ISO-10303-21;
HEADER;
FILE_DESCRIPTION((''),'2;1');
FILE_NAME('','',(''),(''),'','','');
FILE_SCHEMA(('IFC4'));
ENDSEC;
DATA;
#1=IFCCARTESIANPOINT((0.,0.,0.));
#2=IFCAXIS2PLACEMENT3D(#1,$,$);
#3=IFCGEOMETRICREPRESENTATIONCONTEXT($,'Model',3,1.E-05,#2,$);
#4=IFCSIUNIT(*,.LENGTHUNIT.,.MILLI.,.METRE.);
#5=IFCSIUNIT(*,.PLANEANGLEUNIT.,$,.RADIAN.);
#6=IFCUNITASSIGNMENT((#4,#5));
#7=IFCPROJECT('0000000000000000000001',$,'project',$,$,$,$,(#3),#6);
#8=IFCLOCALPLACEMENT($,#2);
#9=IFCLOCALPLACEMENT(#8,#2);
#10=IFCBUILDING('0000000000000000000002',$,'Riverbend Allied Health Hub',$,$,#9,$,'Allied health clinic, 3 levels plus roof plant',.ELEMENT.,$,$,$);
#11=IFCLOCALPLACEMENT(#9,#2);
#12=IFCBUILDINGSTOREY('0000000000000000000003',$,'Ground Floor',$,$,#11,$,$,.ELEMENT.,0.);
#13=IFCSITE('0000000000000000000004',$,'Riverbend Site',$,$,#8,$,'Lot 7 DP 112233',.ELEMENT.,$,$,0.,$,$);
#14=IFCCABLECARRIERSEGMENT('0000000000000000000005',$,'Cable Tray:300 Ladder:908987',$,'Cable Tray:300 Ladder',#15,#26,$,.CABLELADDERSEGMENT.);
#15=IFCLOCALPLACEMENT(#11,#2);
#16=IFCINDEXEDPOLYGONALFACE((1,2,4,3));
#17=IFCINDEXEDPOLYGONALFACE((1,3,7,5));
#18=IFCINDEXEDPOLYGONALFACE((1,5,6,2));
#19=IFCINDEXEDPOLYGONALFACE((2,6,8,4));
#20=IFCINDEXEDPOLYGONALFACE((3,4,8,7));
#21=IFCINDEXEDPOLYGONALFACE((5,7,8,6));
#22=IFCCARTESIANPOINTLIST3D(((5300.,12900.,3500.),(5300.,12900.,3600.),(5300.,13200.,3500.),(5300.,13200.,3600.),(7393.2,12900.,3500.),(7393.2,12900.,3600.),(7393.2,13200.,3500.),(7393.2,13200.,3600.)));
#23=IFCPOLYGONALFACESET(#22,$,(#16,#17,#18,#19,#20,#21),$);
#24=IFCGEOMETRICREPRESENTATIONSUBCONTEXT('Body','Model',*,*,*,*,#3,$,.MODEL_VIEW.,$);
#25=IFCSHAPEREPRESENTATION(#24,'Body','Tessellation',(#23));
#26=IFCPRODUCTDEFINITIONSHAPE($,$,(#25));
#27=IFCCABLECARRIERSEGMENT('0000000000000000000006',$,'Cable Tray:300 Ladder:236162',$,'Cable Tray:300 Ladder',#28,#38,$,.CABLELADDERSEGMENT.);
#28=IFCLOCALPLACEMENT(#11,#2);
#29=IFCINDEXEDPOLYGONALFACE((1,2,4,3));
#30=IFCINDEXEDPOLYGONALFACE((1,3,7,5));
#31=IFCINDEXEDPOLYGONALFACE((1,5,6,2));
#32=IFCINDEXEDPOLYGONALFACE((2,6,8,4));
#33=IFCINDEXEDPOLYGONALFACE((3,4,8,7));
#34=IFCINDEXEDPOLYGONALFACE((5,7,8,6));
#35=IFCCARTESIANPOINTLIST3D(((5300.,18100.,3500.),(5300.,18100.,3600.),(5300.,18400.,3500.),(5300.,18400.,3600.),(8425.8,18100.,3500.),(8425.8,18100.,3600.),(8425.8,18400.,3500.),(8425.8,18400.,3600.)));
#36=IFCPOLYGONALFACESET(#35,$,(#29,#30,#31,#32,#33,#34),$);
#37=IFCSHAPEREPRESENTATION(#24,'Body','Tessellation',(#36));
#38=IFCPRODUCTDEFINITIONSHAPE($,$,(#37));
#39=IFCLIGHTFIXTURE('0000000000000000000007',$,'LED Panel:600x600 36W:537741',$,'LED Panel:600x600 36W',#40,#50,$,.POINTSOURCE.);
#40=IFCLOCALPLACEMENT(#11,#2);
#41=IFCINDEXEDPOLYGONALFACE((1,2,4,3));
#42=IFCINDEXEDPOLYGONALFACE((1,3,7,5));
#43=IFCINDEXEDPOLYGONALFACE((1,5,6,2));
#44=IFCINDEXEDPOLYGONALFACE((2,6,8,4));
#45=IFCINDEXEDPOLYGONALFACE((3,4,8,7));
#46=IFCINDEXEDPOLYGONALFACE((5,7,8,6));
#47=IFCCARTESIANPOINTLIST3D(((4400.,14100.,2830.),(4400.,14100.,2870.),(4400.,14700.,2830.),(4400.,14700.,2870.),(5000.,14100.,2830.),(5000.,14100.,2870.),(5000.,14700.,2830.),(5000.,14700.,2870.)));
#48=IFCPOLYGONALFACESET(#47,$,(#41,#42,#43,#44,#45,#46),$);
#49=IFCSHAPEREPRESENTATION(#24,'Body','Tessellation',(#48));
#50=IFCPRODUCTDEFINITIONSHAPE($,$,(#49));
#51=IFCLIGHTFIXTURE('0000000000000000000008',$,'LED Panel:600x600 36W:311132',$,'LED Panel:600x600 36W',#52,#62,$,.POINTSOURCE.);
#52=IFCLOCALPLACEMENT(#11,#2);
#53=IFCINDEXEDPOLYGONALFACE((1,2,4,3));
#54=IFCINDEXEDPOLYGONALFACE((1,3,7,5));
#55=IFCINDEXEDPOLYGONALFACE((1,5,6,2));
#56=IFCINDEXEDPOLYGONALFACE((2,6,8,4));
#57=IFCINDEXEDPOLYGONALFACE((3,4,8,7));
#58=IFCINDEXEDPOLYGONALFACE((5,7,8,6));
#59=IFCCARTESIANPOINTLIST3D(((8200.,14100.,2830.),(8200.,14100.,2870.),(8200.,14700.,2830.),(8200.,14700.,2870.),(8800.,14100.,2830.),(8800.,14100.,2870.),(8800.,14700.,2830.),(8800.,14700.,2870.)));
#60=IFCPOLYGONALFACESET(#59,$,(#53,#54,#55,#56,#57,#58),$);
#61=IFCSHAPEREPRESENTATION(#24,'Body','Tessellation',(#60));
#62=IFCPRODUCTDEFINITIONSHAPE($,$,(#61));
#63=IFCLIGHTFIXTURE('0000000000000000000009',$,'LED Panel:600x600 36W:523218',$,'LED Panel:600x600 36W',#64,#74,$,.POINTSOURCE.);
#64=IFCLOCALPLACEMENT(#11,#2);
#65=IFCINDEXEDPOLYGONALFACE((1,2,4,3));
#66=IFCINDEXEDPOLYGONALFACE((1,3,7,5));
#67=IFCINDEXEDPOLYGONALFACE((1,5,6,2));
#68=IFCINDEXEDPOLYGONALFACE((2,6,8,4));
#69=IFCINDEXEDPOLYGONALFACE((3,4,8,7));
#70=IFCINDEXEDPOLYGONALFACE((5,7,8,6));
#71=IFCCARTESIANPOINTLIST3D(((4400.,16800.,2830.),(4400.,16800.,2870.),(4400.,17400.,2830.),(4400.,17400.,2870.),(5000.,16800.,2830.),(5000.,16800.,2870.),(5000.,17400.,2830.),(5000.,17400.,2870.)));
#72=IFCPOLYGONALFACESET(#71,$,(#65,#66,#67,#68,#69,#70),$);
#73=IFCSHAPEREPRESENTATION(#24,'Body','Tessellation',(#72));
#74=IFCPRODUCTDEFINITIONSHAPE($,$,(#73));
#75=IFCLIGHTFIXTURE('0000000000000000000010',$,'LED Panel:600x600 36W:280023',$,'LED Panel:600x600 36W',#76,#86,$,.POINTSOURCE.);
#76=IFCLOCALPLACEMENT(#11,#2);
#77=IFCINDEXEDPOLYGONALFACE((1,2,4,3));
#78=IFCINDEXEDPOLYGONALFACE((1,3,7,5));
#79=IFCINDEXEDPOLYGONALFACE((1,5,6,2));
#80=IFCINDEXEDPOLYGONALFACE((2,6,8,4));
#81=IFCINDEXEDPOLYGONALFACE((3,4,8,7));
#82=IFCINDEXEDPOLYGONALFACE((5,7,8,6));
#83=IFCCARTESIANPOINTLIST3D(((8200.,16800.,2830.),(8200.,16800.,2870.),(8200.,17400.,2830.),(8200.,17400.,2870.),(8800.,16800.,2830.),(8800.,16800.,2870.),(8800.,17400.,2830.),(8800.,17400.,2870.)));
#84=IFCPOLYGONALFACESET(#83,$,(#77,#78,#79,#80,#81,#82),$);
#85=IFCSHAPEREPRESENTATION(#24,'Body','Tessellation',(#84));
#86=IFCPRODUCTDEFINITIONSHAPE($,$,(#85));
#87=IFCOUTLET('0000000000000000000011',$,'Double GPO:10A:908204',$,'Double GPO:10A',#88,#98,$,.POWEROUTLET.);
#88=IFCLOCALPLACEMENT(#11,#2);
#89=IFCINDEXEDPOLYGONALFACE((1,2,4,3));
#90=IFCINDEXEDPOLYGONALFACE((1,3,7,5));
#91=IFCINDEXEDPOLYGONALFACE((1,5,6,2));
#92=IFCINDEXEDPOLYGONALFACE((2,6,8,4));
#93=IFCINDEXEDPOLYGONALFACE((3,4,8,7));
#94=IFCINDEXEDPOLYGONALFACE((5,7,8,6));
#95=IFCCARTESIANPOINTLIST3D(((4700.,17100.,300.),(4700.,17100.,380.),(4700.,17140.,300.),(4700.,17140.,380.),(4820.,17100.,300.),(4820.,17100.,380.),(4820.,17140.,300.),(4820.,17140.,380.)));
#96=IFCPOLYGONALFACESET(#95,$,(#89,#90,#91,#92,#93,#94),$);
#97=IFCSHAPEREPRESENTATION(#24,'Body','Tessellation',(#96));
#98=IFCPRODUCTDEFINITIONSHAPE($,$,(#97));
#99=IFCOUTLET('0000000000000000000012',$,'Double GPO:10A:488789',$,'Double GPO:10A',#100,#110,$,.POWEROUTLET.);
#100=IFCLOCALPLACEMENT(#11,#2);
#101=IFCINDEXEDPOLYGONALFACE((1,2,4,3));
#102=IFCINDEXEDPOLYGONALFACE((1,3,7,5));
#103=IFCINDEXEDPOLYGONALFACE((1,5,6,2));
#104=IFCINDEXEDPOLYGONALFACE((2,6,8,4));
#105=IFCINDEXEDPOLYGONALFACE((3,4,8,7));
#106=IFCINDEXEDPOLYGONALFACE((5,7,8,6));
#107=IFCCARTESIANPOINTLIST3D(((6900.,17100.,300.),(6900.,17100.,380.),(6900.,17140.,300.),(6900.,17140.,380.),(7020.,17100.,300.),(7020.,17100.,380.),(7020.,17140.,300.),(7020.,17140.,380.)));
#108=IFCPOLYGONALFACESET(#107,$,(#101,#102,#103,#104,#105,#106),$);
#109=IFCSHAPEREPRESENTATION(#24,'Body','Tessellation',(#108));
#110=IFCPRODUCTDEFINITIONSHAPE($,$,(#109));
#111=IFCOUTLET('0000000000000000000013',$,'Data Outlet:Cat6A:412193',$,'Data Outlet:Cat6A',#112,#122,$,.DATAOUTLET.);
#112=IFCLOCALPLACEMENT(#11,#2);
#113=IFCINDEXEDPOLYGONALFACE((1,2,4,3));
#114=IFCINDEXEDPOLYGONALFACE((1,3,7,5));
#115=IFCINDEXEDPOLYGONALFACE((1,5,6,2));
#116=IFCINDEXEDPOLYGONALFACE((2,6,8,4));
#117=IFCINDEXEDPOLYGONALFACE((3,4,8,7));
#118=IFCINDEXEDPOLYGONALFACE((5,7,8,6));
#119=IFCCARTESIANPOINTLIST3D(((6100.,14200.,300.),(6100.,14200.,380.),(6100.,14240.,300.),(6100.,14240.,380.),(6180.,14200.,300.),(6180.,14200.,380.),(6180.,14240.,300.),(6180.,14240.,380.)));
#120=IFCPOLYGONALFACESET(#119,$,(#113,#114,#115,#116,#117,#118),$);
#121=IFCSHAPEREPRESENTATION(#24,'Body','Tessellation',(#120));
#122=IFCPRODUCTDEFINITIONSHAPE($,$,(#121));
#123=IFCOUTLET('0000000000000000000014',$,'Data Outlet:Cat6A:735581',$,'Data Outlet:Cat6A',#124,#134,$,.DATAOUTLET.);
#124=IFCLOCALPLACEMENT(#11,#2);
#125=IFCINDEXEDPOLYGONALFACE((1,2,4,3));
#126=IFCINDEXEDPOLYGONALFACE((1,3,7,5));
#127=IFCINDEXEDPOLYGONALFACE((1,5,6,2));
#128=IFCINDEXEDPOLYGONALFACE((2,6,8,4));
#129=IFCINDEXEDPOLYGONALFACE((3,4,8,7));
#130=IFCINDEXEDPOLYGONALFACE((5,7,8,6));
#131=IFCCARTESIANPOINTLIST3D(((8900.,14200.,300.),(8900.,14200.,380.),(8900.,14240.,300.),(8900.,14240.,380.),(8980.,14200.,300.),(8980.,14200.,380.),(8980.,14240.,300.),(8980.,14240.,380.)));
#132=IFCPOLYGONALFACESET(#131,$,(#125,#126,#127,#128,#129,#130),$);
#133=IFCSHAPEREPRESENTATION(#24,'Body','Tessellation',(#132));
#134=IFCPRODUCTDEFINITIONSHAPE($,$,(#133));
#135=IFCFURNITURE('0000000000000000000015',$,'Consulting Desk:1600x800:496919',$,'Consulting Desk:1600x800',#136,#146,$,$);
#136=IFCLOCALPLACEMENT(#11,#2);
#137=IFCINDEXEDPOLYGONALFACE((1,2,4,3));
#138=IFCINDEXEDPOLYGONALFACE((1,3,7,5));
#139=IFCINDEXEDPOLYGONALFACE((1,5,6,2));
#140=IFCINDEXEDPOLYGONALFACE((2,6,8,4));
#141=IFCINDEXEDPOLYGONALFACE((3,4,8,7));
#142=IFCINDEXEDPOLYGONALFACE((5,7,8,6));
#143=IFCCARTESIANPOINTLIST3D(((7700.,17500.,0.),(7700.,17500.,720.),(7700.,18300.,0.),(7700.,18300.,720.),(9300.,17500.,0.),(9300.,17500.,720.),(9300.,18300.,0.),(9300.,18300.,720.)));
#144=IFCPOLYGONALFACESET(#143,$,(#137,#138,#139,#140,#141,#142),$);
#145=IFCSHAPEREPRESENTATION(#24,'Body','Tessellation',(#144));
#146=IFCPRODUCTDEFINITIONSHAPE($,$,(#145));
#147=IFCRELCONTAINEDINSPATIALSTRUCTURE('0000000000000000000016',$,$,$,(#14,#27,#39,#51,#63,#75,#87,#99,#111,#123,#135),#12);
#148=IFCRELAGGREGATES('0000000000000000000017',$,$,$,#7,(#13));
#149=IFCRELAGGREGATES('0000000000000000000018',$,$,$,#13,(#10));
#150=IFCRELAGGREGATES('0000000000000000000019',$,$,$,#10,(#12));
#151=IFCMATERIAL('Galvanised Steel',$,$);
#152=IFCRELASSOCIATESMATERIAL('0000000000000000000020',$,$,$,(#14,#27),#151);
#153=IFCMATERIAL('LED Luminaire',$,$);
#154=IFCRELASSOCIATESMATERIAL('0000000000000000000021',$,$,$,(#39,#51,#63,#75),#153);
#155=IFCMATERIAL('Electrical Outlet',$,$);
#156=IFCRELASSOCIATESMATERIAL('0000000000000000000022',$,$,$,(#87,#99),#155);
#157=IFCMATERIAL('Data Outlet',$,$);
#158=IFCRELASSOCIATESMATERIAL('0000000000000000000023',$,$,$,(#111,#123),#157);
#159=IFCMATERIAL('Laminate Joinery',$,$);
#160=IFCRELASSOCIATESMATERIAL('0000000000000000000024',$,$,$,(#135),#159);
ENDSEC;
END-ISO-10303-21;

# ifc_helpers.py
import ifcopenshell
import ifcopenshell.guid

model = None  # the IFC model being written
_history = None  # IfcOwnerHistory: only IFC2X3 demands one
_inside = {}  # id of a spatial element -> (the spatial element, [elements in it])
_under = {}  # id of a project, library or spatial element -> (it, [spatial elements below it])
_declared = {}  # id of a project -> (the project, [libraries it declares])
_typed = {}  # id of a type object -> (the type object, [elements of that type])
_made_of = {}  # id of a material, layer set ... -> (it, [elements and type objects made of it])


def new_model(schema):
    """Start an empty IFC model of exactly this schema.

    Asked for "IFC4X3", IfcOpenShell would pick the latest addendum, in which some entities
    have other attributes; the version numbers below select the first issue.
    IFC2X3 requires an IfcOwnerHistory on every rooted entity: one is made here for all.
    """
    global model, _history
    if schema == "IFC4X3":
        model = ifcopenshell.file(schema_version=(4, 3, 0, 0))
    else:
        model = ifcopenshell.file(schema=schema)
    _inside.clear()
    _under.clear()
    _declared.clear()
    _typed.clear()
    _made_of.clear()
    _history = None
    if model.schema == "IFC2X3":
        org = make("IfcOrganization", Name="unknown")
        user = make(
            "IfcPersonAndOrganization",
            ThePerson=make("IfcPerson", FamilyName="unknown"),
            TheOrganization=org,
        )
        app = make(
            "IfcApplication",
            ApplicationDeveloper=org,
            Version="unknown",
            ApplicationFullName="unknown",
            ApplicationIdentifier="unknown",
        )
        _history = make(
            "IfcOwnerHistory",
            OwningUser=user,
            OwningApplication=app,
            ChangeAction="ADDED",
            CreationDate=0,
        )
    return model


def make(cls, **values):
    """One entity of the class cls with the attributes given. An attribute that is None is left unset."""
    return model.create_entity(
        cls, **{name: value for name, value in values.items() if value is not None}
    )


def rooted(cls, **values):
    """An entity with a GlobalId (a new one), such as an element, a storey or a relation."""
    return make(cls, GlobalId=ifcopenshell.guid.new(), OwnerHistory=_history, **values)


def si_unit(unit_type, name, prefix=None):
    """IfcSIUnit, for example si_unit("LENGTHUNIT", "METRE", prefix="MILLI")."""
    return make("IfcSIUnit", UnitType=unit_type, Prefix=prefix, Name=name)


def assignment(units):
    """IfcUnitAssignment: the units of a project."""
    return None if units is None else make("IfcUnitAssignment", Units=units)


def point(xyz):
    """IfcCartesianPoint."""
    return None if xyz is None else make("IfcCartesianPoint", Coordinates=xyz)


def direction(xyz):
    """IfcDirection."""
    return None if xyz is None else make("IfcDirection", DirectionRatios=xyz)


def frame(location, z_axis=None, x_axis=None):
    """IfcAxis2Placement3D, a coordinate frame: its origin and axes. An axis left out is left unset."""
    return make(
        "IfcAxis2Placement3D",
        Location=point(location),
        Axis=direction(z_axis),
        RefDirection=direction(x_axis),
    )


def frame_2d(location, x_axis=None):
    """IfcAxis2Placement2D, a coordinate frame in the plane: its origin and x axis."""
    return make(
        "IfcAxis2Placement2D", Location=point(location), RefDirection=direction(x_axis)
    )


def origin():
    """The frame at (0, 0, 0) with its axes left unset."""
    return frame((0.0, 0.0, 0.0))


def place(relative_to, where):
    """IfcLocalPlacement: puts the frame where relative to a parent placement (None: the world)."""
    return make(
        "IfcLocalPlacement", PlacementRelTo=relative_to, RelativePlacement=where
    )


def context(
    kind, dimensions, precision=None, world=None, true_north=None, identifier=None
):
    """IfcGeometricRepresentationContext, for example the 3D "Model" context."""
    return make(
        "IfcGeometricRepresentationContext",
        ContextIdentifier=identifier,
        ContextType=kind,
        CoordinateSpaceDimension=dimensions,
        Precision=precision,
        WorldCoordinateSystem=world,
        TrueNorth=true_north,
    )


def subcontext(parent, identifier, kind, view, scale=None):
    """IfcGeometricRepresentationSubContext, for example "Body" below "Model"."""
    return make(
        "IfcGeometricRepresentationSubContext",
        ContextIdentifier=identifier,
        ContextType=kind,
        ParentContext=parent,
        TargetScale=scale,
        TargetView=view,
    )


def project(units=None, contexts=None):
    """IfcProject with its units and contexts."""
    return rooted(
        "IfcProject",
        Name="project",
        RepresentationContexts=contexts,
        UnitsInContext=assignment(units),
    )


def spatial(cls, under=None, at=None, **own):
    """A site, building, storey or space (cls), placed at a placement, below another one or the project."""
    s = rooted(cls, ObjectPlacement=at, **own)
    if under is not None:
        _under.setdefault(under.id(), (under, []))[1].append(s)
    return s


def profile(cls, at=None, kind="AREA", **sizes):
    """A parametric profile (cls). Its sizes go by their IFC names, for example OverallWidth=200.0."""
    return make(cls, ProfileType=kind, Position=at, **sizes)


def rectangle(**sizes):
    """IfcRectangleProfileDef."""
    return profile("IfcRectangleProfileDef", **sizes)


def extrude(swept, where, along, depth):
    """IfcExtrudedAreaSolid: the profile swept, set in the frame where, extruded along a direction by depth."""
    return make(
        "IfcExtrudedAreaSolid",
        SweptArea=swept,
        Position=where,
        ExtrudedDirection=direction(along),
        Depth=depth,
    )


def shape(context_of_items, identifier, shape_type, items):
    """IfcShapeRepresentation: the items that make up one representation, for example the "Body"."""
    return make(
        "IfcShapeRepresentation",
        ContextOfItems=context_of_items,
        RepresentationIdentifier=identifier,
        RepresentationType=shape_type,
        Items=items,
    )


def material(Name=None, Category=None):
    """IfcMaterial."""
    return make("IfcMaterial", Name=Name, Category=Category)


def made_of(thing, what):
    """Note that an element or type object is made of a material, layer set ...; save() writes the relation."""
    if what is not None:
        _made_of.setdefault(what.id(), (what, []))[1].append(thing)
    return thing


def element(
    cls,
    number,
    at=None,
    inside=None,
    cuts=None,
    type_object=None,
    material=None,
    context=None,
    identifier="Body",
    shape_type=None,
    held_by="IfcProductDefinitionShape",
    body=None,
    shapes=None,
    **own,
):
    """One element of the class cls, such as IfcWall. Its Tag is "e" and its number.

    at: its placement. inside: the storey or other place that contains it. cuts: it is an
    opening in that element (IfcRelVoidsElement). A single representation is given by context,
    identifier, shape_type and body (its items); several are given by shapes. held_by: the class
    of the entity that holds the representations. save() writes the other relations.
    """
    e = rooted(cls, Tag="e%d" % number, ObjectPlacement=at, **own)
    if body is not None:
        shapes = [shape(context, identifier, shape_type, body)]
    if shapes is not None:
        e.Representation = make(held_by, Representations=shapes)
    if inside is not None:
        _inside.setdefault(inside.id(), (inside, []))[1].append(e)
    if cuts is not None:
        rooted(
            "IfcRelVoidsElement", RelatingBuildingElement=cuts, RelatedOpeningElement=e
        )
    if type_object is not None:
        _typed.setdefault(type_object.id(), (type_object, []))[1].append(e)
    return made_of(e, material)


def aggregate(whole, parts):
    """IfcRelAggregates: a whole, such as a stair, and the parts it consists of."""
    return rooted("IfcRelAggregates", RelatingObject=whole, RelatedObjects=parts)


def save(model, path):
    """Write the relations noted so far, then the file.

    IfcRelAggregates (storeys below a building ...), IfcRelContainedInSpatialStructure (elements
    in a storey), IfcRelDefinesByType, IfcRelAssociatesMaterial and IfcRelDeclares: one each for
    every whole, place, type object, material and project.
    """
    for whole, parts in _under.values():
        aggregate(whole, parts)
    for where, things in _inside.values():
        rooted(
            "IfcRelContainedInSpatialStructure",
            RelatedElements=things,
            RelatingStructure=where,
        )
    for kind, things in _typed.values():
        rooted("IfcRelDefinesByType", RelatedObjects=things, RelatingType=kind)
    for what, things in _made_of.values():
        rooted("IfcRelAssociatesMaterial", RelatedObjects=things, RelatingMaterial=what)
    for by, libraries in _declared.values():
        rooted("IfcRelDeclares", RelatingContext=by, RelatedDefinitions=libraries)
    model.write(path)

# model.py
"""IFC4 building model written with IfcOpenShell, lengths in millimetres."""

from ifc_helpers import new_model, si_unit, frame, frame_2d, origin, place, context, subcontext, project, spatial, rectangle, extrude, material, element, save


model = new_model("IFC4")

# Units and contexts
model_context = context("Model", 3, precision=1e-05, world=origin())
body_context = subcontext(model_context, "Body", "Model", "MODEL_VIEW")
ifc_project = project(units=[si_unit("LENGTHUNIT", "METRE", prefix="MILLI"), si_unit("PLANEANGLEUNIT", "RADIAN")], contexts=[model_context])

# Site, building, storey
site_placement = place(None, origin())
site = spatial("IfcSite", under=ifc_project, at=site_placement, Name="Riverbend Site", LongName="Lot 7 DP 112233", CompositionType="ELEMENT", RefElevation=0.0)
building_placement = place(site_placement, origin())
building = spatial("IfcBuilding", under=site, at=building_placement, Name="Riverbend Allied Health Hub", LongName="Allied health clinic, 3 levels plus roof plant", CompositionType="ELEMENT")
storey_placement = place(building_placement, origin())
storey = spatial("IfcBuildingStorey", under=building, at=storey_placement, Name="Ground Floor", CompositionType="ELEMENT", Elevation=0.0)

# Shared definitions
ifc_material_1 = material(Name="Galvanised Steel")

# Cable carrier segments
cable_carrier_segment_1_placement = place(storey_placement, frame((5300.0, 12900.0, 3500.0)))
element("IfcCableCarrierSegment", 1, at=cable_carrier_segment_1_placement, inside=storey, material=ifc_material_1, Name="Cable Tray:300 Ladder:908987", ObjectType="Cable Tray:300 Ladder", PredefinedType="CABLELADDERSEGMENT", context=body_context, shape_type="SweptSolid", body=[
    extrude(rectangle(XDim=2093.2, YDim=300.0, at=frame_2d((1046.6, 150.0))), origin(), (0.0, 0.0, 1.0), 100.0),
])
cable_carrier_segment_2_placement = place(storey_placement, frame((5300.0, 18100.0, 3500.0)))
element("IfcCableCarrierSegment", 2, at=cable_carrier_segment_2_placement, inside=storey, material=ifc_material_1, Name="Cable Tray:300 Ladder:236162", ObjectType="Cable Tray:300 Ladder", PredefinedType="CABLELADDERSEGMENT", context=body_context, shape_type="SweptSolid", body=[
    extrude(rectangle(XDim=3125.8, YDim=300.0, at=frame_2d((1562.9, 150.0))), origin(), (0.0, 0.0, 1.0), 100.0),
])

# Light fixtures
ifc_material_2 = material(Name="LED Luminaire")
for number, where, name in (
    (3, (4400.0, 14100.0, 2830.0), "LED Panel:600x600 36W:537741"),
    (4, (8200.0, 14100.0, 2830.0), "LED Panel:600x600 36W:311132"),
    (5, (4400.0, 16800.0, 2830.0), "LED Panel:600x600 36W:523218"),
    (6, (8200.0, 16800.0, 2830.0), "LED Panel:600x600 36W:280023"),
):
    element("IfcLightFixture", number, at=place(storey_placement, frame(where)), inside=storey, material=ifc_material_2, Name=name, ObjectType="LED Panel:600x600 36W", PredefinedType="POINTSOURCE", context=body_context, shape_type="SweptSolid", body=[
        extrude(rectangle(XDim=600.0, YDim=600.0, at=frame_2d((300.0, 300.0))), origin(), (0.0, 0.0, 1.0), 40.0),
    ])

# Outlets
ifc_material_3 = material(Name="Electrical Outlet")
for number, where, name in (
    (7, (4700.0, 17100.0, 300.0), "Double GPO:10A:908204"),
    (8, (6900.0, 17100.0, 300.0), "Double GPO:10A:488789"),
):
    element("IfcOutlet", number, at=place(storey_placement, frame(where)), inside=storey, material=ifc_material_3, Name=name, ObjectType="Double GPO:10A", PredefinedType="POWEROUTLET", context=body_context, shape_type="SweptSolid", body=[
        extrude(rectangle(XDim=120.0, YDim=40.0, at=frame_2d((60.0, 20.0))), origin(), (0.0, 0.0, 1.0), 80.0),
    ])
ifc_material_4 = material(Name="Data Outlet")
for number, where, name in (
    (9, (6100.0, 14200.0, 300.0), "Data Outlet:Cat6A:412193"),
    (10, (8900.0, 14200.0, 300.0), "Data Outlet:Cat6A:735581"),
):
    element("IfcOutlet", number, at=place(storey_placement, frame(where)), inside=storey, material=ifc_material_4, Name=name, ObjectType="Data Outlet:Cat6A", PredefinedType="DATAOUTLET", context=body_context, shape_type="SweptSolid", body=[
        extrude(rectangle(XDim=80.0, YDim=40.0, at=frame_2d((40.0, 20.0))), origin(), (0.0, 0.0, 1.0), 80.0),
    ])

# Furniture
ifc_material_5 = material(Name="Laminate Joinery")
furniture_placement = place(storey_placement, frame((7700.0, 17500.0, 0.0)))
element("IfcFurniture", 11, at=furniture_placement, inside=storey, material=ifc_material_5, Name="Consulting Desk:1600x800:496919", ObjectType="Consulting Desk:1600x800", context=body_context, shape_type="SweptSolid", body=[
    extrude(rectangle(XDim=1600.0, YDim=800.0, at=frame_2d((800.0, 400.0))), origin(), (0.0, 0.0, 1.0), 720.0),
])

save(model, "model.ifc")
